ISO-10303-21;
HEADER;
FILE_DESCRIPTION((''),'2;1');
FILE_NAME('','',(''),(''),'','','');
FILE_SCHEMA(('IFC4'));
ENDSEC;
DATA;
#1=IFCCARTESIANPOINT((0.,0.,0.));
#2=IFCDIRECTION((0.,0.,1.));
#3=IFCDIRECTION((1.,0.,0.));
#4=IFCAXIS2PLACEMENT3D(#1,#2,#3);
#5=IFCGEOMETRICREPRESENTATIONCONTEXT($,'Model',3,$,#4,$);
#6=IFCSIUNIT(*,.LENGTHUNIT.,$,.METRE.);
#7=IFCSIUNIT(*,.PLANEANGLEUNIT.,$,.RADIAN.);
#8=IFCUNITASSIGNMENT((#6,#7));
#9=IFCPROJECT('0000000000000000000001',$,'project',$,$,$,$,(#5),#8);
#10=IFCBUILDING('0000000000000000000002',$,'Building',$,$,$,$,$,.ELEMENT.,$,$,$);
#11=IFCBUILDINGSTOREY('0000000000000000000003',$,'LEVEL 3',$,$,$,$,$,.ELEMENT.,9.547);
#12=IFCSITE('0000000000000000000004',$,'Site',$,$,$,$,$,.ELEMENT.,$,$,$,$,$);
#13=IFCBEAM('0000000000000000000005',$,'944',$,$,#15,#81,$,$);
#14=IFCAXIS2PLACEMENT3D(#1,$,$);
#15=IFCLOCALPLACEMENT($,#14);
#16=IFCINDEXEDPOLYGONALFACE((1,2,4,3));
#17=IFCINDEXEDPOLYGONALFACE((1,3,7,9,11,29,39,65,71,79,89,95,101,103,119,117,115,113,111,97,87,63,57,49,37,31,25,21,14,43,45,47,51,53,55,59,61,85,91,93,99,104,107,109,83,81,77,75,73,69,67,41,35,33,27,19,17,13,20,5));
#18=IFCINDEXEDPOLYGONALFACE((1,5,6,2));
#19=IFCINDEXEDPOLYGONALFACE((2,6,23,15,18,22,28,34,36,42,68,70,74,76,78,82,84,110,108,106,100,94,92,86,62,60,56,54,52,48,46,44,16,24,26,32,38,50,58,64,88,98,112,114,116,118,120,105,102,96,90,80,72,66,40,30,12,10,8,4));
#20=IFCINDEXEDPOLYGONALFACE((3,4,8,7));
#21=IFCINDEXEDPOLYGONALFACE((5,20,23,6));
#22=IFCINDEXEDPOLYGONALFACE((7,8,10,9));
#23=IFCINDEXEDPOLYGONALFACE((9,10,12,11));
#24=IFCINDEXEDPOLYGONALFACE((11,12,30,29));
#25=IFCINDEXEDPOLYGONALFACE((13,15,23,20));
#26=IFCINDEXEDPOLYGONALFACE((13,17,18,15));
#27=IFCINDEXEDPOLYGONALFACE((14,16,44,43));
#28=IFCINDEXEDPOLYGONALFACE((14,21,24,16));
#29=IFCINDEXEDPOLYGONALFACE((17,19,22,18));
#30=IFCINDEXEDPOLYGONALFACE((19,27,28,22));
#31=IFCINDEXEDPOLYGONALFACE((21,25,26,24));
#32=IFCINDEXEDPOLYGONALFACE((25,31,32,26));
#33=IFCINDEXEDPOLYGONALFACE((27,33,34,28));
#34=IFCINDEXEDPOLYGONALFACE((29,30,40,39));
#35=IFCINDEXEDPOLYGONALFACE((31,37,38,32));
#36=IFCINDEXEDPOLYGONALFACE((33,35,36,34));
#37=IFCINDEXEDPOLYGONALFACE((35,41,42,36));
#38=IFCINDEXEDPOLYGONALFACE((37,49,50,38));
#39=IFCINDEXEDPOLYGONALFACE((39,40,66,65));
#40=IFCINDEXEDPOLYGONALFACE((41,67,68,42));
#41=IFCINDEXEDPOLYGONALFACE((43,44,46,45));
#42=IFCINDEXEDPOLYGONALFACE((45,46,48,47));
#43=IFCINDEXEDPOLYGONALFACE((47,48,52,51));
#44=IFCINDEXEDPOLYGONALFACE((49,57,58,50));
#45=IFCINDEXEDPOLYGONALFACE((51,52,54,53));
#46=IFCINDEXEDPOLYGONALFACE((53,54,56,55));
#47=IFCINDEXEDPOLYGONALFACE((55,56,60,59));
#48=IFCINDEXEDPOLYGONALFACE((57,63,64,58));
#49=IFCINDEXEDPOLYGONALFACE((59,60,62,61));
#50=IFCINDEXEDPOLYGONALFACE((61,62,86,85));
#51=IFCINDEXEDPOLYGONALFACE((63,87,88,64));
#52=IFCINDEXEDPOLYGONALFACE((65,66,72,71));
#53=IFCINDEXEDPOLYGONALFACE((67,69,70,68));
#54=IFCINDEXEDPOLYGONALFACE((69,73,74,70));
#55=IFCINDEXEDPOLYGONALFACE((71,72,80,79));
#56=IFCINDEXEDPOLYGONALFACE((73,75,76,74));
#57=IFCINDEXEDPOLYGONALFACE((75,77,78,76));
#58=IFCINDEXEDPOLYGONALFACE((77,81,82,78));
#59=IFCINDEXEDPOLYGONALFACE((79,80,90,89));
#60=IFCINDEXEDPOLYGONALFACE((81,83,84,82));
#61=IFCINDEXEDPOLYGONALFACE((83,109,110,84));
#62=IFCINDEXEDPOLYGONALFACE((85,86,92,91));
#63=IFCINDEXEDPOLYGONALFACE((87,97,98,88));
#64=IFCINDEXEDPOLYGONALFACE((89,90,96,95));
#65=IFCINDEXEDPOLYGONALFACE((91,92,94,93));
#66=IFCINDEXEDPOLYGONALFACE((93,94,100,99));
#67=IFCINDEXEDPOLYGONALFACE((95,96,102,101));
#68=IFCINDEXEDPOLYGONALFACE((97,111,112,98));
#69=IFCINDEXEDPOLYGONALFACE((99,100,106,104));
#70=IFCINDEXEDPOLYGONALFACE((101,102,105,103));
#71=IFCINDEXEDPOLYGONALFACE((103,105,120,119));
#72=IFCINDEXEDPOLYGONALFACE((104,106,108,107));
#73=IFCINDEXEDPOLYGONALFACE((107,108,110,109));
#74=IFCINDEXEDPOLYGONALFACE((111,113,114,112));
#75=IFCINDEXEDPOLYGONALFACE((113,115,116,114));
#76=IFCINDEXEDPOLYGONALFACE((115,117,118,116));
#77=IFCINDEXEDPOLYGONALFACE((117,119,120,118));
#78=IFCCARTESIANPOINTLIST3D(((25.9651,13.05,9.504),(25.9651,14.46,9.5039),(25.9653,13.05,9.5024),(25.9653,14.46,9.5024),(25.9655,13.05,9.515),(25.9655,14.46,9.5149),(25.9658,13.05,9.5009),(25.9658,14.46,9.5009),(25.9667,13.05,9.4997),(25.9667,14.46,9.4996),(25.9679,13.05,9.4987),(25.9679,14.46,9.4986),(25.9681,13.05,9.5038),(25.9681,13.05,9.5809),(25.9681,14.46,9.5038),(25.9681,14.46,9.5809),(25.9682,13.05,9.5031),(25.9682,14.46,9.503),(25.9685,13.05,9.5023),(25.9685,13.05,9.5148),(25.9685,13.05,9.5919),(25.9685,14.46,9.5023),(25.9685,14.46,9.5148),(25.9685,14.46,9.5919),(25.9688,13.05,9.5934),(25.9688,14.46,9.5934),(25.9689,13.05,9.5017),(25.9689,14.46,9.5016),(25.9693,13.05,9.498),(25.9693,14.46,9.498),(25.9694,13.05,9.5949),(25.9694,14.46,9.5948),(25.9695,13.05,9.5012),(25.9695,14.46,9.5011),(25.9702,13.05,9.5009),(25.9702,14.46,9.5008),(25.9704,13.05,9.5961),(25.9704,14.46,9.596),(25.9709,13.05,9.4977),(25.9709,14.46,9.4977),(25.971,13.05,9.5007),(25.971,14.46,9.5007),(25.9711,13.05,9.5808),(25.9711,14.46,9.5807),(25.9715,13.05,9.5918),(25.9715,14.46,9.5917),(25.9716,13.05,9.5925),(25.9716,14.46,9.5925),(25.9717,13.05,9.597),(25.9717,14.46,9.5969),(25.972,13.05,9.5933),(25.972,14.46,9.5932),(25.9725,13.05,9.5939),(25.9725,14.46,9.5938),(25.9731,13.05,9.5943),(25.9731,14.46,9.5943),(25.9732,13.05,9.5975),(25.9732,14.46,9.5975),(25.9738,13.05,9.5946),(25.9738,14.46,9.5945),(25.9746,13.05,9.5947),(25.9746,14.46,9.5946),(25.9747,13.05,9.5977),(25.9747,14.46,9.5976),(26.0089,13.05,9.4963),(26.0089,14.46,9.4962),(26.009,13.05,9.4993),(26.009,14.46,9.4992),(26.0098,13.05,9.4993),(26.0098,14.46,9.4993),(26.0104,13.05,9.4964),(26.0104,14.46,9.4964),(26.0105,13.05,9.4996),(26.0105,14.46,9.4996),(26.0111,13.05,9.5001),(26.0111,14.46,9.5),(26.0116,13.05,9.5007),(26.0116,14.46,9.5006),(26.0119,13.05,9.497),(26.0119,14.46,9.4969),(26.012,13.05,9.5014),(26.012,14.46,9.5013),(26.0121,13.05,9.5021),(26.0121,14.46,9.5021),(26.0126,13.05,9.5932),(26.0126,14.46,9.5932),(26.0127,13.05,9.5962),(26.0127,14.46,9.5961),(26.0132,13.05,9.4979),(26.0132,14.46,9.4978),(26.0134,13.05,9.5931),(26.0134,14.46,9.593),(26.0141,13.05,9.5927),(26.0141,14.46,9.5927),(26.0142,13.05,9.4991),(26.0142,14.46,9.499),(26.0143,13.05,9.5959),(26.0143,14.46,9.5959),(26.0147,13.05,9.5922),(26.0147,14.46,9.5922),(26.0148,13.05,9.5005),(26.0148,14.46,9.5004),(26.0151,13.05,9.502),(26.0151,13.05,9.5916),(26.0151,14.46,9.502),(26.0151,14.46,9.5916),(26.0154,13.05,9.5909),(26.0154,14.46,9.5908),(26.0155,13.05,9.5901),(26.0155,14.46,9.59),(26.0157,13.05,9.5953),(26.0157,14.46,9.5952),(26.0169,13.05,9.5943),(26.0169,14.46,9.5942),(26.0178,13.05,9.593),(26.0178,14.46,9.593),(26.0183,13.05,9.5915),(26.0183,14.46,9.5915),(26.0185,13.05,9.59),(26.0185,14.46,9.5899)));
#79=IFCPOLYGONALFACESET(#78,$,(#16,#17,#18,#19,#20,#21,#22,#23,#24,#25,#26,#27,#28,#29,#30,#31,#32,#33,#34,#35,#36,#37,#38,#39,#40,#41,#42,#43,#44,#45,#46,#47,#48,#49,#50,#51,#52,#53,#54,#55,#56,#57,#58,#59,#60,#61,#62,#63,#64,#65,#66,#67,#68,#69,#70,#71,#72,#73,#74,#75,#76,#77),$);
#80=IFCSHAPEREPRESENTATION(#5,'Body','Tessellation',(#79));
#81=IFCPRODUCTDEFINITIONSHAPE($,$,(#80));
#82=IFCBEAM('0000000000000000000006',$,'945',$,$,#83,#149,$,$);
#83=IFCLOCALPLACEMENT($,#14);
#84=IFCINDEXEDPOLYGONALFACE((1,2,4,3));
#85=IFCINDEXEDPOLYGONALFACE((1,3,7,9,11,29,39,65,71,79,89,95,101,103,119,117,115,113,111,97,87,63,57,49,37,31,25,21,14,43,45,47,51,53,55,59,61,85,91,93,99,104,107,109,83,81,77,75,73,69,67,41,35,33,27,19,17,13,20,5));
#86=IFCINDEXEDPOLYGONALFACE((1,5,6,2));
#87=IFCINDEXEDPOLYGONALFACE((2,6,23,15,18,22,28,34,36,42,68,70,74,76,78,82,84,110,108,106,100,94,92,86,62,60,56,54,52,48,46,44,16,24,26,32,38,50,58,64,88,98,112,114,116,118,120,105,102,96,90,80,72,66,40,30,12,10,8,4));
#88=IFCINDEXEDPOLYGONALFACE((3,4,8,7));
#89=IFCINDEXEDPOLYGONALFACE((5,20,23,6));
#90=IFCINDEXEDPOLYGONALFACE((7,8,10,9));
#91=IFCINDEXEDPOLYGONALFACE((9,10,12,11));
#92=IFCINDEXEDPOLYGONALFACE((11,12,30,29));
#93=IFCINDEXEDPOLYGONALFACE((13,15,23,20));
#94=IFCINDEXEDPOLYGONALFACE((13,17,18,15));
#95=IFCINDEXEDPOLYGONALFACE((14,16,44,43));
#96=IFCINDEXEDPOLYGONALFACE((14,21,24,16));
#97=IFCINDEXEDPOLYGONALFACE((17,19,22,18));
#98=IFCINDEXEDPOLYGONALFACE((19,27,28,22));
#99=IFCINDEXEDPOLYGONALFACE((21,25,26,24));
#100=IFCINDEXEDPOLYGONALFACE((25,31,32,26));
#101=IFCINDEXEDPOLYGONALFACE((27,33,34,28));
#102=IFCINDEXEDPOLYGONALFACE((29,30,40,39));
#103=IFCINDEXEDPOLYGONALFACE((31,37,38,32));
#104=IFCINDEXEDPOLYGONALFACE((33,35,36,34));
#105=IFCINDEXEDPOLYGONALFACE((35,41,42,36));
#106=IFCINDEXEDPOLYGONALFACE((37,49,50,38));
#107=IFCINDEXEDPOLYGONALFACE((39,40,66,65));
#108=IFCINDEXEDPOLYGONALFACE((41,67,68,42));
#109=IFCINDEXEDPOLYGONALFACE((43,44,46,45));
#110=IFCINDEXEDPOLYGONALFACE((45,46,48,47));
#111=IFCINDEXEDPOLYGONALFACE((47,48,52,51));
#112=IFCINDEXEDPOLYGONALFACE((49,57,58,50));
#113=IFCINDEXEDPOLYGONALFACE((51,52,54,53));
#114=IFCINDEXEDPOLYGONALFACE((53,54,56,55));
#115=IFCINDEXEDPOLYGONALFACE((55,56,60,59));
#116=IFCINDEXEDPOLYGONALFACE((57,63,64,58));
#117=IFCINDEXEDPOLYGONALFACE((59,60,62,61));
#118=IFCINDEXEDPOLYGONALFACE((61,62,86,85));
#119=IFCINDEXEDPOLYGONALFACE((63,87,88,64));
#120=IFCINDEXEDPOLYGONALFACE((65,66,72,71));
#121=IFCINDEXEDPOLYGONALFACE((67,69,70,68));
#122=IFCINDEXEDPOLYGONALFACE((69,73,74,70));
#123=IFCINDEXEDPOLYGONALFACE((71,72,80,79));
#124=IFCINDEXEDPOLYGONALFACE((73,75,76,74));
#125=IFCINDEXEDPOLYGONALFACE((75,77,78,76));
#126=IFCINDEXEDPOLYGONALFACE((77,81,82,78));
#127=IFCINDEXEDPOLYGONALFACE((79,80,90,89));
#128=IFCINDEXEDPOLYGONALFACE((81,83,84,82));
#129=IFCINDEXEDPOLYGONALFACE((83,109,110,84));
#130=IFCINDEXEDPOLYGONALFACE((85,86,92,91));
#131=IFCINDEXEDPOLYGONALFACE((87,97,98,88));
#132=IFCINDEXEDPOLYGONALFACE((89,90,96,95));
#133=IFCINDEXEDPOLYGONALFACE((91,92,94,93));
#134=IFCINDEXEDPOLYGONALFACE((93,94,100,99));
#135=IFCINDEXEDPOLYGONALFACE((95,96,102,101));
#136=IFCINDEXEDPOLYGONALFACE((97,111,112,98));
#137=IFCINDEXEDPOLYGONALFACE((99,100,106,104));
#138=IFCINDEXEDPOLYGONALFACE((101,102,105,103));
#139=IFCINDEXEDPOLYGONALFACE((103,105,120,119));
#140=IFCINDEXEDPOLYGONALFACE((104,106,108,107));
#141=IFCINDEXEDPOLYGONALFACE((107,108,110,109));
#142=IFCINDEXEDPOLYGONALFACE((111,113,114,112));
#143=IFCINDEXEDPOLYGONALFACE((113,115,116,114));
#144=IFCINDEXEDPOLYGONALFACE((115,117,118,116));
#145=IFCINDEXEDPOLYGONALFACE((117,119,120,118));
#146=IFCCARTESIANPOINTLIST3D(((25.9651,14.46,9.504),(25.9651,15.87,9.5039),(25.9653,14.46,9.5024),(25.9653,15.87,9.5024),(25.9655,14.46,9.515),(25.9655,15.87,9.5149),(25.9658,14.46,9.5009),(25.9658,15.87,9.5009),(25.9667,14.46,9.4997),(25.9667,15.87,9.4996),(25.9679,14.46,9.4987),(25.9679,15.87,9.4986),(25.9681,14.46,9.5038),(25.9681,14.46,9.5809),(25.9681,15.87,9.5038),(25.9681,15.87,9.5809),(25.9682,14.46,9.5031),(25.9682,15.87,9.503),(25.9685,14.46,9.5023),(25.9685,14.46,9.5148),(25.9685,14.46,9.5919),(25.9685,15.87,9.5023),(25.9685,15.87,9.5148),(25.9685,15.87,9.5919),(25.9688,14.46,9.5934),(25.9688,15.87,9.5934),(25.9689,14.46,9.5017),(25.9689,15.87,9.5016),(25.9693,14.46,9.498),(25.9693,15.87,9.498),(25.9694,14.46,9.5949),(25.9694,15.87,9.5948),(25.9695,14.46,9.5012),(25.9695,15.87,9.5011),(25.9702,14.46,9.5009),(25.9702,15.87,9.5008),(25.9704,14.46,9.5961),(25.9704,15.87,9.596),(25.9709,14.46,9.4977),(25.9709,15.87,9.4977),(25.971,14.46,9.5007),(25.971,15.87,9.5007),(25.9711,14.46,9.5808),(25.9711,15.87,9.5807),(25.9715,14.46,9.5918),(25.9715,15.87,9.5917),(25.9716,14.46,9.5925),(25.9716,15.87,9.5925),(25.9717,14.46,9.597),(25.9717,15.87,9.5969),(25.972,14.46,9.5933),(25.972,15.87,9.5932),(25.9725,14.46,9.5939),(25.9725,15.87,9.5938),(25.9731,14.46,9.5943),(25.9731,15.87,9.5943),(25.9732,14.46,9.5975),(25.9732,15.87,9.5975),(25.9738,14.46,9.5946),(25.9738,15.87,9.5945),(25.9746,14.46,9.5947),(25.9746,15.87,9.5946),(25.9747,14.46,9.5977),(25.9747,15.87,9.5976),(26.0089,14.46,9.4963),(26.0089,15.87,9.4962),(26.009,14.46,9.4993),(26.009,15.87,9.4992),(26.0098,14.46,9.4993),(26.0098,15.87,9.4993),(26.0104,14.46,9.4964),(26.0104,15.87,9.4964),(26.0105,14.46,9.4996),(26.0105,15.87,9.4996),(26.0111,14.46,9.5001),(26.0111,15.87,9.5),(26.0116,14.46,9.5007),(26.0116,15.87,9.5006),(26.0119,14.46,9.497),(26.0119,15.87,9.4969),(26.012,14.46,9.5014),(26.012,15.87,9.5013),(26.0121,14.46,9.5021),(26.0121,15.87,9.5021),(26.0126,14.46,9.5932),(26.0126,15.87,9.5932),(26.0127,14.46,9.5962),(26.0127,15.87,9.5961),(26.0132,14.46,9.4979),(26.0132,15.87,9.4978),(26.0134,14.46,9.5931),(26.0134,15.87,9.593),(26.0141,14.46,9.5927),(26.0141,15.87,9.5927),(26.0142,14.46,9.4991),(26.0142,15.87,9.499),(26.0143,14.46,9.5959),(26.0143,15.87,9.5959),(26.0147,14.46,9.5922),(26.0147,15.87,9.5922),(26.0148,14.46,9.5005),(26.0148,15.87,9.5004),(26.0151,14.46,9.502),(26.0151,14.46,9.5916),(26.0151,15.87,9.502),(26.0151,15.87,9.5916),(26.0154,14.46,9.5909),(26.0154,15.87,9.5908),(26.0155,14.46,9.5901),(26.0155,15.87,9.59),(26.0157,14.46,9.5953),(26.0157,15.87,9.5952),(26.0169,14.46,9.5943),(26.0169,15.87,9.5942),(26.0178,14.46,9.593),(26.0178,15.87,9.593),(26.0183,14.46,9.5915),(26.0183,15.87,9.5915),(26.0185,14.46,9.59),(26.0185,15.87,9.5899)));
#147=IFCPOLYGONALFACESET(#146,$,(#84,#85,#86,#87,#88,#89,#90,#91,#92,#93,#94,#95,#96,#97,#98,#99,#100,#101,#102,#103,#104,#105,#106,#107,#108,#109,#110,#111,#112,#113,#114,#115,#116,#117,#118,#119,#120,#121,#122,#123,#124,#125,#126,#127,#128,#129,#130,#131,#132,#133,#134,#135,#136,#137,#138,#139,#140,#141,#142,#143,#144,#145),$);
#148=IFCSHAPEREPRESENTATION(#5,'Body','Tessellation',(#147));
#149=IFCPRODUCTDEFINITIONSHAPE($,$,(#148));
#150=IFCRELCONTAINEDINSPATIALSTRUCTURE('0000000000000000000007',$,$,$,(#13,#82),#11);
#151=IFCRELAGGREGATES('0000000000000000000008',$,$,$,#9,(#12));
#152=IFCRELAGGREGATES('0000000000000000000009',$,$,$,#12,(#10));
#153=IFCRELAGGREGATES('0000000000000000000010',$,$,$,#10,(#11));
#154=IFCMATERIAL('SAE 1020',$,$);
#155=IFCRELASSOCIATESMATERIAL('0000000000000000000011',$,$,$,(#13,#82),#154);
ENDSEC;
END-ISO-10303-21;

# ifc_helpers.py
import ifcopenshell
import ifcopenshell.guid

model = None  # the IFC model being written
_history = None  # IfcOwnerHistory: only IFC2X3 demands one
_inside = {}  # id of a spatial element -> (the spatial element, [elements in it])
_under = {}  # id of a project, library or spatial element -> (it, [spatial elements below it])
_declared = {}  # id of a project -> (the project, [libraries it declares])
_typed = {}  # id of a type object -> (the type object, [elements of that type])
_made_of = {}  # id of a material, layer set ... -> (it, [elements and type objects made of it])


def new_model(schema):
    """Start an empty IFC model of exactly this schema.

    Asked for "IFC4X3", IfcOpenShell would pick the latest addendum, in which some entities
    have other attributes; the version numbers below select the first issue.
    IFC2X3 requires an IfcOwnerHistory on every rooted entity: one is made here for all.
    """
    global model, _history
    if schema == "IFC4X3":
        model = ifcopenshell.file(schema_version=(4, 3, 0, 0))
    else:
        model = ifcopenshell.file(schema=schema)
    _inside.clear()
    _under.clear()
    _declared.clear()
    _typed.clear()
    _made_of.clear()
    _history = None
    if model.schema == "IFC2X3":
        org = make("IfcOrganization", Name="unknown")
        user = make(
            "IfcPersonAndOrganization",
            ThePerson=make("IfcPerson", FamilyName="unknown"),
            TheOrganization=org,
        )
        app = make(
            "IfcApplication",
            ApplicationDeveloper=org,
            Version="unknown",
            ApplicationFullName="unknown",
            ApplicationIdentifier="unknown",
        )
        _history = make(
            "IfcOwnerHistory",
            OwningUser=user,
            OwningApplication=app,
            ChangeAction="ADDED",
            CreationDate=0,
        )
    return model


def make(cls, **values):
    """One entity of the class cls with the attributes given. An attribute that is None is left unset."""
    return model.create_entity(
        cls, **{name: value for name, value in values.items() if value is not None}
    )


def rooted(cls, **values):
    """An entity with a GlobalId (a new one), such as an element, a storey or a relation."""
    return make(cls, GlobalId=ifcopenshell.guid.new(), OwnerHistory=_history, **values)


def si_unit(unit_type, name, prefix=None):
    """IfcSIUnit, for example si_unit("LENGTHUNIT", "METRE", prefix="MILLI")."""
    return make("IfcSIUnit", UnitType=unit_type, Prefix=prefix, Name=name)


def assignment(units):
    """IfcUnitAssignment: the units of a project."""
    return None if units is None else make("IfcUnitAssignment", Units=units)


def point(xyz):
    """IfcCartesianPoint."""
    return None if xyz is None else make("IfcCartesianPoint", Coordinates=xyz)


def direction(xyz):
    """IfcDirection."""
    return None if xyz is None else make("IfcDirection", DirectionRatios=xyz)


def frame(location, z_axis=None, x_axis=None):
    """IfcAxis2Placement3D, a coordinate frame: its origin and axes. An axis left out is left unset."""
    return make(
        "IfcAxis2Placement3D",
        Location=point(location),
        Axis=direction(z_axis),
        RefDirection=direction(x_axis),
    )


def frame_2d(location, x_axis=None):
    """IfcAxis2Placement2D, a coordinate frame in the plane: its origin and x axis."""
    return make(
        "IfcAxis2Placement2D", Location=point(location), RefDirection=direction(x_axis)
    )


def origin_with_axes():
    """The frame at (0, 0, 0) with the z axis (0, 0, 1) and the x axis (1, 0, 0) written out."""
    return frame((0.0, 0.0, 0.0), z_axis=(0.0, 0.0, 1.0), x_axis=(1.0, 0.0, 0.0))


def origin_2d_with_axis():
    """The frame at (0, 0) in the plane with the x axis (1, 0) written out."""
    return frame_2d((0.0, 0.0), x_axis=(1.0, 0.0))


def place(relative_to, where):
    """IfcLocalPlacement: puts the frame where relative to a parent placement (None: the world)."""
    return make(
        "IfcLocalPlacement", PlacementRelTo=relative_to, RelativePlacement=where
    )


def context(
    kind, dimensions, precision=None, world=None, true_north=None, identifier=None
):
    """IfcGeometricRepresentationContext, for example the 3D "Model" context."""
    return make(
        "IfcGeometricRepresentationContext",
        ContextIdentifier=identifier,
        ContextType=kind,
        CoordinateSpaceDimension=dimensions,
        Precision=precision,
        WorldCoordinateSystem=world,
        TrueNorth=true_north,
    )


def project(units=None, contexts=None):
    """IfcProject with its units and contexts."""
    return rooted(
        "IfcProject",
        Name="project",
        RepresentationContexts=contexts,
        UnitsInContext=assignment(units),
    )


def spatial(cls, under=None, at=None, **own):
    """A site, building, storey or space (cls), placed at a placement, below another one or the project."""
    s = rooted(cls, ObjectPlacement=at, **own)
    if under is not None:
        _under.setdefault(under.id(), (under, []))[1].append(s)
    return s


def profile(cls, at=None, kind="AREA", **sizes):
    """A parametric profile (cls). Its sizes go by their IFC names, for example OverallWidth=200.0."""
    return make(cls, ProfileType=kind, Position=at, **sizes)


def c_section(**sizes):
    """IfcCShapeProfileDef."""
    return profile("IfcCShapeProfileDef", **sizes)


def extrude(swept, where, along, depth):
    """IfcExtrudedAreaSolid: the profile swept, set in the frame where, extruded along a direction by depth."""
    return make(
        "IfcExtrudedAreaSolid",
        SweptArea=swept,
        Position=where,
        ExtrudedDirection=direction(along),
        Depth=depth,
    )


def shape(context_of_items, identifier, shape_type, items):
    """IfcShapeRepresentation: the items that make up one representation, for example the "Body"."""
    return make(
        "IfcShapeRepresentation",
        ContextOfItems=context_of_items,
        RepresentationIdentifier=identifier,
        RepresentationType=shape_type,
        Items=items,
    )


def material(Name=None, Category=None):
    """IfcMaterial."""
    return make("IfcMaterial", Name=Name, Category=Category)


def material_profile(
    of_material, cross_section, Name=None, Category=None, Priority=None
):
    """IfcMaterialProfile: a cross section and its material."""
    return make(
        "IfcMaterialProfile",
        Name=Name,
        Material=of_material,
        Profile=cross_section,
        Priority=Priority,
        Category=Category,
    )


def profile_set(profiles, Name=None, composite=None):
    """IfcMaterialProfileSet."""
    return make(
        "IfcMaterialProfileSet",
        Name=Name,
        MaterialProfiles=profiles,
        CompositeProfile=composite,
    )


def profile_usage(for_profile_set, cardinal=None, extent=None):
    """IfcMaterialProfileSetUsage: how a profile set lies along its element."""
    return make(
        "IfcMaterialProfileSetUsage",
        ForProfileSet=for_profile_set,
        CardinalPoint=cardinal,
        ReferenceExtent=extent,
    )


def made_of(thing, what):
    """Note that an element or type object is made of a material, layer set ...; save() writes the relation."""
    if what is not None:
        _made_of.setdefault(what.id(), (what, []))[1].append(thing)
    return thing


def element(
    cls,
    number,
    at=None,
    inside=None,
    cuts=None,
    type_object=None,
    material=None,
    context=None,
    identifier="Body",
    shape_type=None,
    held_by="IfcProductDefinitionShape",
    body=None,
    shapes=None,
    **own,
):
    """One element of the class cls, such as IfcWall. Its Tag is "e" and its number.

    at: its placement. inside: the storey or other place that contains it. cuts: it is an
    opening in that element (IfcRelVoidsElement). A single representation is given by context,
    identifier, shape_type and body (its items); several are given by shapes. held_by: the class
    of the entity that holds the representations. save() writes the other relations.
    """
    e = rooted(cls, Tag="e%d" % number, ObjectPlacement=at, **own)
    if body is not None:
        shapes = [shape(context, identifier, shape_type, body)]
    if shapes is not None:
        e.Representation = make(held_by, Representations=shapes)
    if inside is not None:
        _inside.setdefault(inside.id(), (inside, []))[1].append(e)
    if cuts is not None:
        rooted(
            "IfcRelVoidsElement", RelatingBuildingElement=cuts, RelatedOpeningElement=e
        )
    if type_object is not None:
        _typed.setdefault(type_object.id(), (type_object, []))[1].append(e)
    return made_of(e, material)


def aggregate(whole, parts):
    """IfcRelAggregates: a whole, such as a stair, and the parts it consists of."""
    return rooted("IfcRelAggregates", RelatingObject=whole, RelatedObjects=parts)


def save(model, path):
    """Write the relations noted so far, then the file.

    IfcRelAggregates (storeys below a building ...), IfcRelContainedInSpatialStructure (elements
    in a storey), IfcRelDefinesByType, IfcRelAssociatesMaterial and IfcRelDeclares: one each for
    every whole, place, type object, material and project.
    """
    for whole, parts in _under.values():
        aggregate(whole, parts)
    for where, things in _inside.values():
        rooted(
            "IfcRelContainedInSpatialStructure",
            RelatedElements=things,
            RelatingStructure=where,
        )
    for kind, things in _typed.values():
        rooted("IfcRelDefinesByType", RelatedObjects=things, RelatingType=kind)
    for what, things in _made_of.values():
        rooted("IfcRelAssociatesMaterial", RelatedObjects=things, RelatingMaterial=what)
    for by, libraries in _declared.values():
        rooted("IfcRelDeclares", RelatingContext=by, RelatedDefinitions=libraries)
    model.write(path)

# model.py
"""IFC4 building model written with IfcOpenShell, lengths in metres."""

from ifc_helpers import new_model, si_unit, frame, origin_with_axes, origin_2d_with_axis, place, context, project, spatial, c_section, extrude, material, material_profile, profile_set, profile_usage, element, save


model = new_model("IFC4")

# Units and contexts
model_context = context("Model", 3, world=origin_with_axes())
ifc_project = project(units=[si_unit("LENGTHUNIT", "METRE"), si_unit("PLANEANGLEUNIT", "RADIAN")], contexts=[model_context])

# Site, building, storey
site = spatial("IfcSite", under=ifc_project, Name="Site", CompositionType="ELEMENT")
building = spatial("IfcBuilding", under=site, Name="Building", CompositionType="ELEMENT")
storey = spatial("IfcBuildingStorey", under=building, Name="LEVEL 3", CompositionType="ELEMENT", Elevation=9.547)

# Beams
ifc_material = material(Name="SAE 1020")
ifc_material_profile_1 = material_profile(ifc_material, c_section(Depth=0.1, Width=0.05, WallThickness=0.003, Girth=0.017, InternalFilletRadius=0.003, at=origin_2d_with_axis()))
ifc_profile_set_1 = profile_set([ifc_material_profile_1])
ifc_profile_usage_1 = profile_usage(ifc_profile_set_1, cardinal=10)
beam_1_placement = place(None, frame((25.9918, 13.05, 9.547), z_axis=(0.0, 1.0, -0.00003), x_axis=(-0.999256, 0.000001, 0.038562)))
element("IfcBeam", 1, at=beam_1_placement, inside=storey, material=ifc_profile_usage_1, Name="944", context=model_context, shape_type="SweptSolid", body=[
    extrude(c_section(Depth=0.1, Width=0.05, WallThickness=0.003, Girth=0.017, InternalFilletRadius=0.003, at=origin_2d_with_axis()), origin_with_axes(), (0.0, 0.0, 1.0), 1.41),
])
ifc_material_profile_2 = material_profile(ifc_material, c_section(Depth=0.1, Width=0.05, WallThickness=0.003, Girth=0.017, InternalFilletRadius=0.003, at=origin_2d_with_axis()))
ifc_profile_set_2 = profile_set([ifc_material_profile_2])
ifc_profile_usage_2 = profile_usage(ifc_profile_set_2, cardinal=10)
beam_2_placement = place(None, frame((25.9918, 14.46, 9.547), z_axis=(0.0, 1.0, -0.00003), x_axis=(-0.999256, 0.000001, 0.038562)))
element("IfcBeam", 2, at=beam_2_placement, inside=storey, material=ifc_profile_usage_2, Name="945", context=model_context, shape_type="SweptSolid", body=[
    extrude(c_section(Depth=0.1, Width=0.05, WallThickness=0.003, Girth=0.017, InternalFilletRadius=0.003, at=origin_2d_with_axis()), origin_with_axes(), (0.0, 0.0, 1.0), 1.41),
])

save(model, "model.ifc")
